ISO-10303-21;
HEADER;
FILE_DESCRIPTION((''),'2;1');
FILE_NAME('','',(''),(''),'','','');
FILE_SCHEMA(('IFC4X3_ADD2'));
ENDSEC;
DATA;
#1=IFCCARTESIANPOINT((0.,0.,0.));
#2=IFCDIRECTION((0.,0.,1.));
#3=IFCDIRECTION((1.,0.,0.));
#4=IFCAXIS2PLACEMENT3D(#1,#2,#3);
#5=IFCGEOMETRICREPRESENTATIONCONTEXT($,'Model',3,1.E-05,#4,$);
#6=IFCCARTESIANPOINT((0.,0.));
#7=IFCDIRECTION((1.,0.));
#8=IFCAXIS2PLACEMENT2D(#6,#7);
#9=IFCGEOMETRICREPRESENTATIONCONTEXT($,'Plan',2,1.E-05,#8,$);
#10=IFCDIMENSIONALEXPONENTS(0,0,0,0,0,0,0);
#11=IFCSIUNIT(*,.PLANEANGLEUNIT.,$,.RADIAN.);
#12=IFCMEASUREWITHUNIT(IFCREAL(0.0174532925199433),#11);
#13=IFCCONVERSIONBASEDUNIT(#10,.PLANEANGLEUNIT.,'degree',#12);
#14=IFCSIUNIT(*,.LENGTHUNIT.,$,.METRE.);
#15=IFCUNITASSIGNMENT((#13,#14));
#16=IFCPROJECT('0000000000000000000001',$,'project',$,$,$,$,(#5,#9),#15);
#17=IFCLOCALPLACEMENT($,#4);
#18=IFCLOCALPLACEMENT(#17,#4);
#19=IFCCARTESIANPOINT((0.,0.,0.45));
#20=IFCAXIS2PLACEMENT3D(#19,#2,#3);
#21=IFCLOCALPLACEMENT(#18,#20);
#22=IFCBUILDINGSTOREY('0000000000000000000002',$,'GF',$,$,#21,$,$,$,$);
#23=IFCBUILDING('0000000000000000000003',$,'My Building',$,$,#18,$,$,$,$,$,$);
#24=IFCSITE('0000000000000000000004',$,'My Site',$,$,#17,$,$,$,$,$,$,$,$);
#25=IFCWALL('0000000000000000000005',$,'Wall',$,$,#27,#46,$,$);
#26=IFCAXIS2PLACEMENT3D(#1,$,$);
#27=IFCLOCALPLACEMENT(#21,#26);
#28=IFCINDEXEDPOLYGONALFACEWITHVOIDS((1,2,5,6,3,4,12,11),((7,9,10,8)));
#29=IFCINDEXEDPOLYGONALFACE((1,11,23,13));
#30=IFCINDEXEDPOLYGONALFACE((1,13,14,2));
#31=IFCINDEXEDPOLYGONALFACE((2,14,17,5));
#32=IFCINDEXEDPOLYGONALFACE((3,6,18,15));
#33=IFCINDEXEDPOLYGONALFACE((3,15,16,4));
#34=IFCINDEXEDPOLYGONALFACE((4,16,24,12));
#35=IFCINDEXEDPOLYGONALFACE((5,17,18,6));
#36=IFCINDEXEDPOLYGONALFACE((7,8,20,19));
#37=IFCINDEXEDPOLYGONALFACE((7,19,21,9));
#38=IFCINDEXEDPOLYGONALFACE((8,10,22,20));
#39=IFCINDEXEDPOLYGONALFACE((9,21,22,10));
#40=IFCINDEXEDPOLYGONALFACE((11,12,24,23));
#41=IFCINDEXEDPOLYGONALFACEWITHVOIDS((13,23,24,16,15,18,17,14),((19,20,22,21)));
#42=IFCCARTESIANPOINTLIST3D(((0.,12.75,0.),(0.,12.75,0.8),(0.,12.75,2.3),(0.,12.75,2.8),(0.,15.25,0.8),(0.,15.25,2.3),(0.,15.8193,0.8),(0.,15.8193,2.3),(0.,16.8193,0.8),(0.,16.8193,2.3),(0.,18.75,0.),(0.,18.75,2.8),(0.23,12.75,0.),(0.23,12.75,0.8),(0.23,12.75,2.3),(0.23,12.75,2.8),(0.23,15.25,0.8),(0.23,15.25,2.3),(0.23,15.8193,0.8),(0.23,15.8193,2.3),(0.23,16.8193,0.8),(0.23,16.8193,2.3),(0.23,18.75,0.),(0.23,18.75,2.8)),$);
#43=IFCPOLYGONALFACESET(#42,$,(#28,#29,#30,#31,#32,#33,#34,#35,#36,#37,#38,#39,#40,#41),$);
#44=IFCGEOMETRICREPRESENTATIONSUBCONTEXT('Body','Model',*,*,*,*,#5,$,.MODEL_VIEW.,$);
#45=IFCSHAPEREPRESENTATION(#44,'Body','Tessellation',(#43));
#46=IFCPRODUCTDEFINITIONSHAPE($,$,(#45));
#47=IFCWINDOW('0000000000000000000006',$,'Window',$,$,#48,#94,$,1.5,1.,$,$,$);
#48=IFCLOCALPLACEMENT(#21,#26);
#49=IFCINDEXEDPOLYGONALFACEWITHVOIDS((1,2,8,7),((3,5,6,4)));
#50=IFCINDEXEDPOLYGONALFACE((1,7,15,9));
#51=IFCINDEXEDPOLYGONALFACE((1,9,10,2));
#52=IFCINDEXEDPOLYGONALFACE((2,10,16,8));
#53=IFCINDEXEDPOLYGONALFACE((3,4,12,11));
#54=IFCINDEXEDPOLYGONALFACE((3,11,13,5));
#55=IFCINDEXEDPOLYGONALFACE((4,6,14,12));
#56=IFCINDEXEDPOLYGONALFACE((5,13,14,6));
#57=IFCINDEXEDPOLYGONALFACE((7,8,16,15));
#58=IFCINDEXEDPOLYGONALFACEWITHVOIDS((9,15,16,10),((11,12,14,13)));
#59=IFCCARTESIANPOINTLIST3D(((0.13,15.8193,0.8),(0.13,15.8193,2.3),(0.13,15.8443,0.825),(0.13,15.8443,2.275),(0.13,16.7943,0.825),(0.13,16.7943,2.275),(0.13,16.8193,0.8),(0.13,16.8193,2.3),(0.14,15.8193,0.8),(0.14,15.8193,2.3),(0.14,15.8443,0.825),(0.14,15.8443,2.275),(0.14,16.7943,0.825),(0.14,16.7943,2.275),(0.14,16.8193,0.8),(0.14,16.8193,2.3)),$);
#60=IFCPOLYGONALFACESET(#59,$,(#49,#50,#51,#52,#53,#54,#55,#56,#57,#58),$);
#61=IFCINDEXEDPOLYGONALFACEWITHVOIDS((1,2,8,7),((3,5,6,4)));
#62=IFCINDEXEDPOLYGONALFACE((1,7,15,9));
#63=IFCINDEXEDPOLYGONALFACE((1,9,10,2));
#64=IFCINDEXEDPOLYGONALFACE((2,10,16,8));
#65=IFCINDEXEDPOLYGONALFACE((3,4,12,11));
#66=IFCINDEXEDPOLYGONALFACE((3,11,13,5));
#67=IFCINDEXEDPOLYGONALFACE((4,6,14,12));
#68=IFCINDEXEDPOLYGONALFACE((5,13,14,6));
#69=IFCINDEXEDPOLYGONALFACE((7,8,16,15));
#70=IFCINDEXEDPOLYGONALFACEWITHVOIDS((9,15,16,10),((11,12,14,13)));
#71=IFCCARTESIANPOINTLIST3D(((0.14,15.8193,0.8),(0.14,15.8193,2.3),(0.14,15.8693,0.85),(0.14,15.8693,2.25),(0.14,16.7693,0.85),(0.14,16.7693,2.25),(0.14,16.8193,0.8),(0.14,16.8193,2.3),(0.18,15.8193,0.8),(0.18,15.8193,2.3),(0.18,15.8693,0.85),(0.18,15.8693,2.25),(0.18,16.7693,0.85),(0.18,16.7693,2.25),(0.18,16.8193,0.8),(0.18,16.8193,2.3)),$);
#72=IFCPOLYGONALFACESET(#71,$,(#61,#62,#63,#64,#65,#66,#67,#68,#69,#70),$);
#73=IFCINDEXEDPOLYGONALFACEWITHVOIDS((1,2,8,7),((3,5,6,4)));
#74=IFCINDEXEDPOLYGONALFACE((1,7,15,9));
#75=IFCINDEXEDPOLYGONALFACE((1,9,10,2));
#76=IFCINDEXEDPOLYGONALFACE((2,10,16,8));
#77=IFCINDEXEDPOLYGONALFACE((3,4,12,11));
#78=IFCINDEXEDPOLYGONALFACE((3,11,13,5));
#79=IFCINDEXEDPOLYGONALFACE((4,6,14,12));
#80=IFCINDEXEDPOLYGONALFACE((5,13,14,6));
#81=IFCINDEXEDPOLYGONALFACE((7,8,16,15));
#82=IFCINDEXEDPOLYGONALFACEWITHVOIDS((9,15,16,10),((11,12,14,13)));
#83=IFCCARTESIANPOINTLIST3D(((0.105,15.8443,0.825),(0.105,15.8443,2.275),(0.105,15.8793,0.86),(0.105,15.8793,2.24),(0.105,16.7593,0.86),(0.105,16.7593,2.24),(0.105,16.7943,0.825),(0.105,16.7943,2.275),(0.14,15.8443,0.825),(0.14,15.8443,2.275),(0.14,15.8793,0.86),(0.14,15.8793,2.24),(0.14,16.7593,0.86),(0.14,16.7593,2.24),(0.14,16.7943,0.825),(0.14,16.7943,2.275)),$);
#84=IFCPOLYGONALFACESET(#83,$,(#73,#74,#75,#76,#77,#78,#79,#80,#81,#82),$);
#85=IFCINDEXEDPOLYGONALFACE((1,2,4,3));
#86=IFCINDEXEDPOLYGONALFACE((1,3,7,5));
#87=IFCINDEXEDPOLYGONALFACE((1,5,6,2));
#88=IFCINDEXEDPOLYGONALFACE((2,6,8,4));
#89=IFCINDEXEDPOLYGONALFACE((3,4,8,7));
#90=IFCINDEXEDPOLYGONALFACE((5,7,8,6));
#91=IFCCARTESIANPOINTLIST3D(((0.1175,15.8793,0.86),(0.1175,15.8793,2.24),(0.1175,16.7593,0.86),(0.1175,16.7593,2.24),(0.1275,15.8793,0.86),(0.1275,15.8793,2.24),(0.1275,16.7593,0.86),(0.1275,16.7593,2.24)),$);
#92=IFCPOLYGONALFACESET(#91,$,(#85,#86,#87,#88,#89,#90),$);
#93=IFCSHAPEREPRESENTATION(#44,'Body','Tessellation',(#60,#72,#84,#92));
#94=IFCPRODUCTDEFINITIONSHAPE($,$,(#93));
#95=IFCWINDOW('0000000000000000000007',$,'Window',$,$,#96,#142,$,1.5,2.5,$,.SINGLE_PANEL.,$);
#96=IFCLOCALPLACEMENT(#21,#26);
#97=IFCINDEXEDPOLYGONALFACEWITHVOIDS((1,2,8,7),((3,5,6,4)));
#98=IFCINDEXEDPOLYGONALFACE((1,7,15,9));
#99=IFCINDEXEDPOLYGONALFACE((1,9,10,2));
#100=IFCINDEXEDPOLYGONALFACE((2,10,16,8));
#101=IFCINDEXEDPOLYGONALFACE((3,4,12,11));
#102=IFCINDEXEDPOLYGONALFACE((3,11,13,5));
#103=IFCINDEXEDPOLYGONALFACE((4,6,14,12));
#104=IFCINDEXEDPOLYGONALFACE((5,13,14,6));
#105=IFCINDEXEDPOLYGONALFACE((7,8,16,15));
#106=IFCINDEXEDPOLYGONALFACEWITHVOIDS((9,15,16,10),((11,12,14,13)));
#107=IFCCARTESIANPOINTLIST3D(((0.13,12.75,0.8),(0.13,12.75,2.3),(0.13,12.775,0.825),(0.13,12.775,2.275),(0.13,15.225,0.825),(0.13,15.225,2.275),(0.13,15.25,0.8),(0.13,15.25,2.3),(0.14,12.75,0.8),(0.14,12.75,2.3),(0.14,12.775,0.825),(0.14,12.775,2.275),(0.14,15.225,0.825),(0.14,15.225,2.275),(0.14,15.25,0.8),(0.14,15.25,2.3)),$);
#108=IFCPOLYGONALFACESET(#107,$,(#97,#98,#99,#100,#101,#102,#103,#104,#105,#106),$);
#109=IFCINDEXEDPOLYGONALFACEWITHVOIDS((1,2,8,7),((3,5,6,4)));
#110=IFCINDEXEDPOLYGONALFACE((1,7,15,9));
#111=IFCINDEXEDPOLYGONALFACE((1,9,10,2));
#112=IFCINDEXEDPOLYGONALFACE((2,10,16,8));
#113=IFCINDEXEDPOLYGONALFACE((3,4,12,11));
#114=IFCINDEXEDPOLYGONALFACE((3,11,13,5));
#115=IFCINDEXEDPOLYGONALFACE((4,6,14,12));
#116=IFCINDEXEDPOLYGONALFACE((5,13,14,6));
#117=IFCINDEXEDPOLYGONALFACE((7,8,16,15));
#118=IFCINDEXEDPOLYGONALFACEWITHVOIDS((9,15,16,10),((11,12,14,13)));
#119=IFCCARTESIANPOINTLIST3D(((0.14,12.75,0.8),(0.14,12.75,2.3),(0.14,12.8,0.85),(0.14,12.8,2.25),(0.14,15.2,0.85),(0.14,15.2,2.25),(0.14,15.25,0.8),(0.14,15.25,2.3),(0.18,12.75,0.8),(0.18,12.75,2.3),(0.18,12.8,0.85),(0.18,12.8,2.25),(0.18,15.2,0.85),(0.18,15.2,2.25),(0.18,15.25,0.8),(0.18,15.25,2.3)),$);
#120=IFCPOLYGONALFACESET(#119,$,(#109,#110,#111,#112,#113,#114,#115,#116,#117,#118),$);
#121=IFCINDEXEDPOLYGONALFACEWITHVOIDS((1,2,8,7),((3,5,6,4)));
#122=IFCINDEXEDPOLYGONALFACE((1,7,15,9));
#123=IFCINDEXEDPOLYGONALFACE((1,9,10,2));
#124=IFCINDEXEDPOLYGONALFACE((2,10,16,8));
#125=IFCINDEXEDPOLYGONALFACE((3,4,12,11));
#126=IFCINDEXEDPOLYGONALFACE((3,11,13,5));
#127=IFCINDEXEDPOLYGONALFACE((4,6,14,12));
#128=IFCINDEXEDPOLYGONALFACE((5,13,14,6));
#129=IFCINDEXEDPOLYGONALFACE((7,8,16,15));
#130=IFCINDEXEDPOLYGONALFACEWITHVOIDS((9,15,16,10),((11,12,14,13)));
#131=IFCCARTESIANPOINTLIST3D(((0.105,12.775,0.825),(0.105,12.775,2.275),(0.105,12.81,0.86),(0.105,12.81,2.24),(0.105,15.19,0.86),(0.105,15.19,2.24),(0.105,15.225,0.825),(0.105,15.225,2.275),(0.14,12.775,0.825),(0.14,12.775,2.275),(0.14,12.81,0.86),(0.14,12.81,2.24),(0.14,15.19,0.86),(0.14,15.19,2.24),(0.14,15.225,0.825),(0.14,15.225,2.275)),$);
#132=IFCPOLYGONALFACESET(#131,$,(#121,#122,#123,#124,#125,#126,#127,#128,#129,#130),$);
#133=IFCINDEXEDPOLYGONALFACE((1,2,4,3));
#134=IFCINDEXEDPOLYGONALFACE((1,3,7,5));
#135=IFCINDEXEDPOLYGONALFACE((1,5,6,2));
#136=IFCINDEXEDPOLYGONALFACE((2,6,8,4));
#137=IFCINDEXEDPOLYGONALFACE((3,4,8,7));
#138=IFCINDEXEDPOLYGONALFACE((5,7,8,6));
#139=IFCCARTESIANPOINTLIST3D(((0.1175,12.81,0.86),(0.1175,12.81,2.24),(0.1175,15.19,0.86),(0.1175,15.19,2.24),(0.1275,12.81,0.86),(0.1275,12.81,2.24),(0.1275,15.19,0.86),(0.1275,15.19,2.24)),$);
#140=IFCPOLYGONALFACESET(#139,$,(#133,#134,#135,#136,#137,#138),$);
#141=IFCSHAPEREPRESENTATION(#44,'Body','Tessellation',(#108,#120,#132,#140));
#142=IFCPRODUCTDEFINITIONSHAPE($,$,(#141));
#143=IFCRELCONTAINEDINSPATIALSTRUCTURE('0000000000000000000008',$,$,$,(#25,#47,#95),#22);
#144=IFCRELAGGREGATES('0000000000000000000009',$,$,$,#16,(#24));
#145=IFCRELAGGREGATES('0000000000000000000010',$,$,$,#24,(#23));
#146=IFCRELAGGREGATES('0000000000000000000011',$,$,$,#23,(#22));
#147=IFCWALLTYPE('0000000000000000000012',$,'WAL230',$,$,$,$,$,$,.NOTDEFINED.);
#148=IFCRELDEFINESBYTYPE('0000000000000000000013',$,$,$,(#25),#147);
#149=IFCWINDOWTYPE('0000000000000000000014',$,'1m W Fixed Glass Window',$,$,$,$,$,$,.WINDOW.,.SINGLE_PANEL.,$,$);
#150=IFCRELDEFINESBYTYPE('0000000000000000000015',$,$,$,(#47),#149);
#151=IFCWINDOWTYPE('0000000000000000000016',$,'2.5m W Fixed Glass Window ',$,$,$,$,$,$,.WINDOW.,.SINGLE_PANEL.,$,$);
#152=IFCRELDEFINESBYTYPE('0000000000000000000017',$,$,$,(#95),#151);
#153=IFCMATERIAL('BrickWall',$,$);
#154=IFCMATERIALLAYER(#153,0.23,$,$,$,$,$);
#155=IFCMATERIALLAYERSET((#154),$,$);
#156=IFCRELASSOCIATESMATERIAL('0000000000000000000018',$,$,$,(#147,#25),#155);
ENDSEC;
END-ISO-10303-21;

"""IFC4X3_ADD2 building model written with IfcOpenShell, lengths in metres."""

from ifc_helpers import new_model, entity, si_unit, converted_unit, frame, origin_with_axes, origin_2d_with_axis, place, context, subcontext, project, spatial, line, indexed_curve, outline, extrude, shape, source, transform, mapped, material, layer, layer_set, layer_usage, type_object, type_shapes, element, fill, save


model = new_model("IFC4X3_ADD2")

# Units and contexts
model_context = context("Model", 3, precision=1e-05, world=origin_with_axes())
plan_context = context("Plan", 2, precision=1e-05, world=origin_2d_with_axis())
body_context_1 = subcontext(model_context, "Body", "Model", "MODEL_VIEW")
body_context_2 = subcontext(plan_context, "Body", "Plan", "PLAN_VIEW")
ifc_project = project(units=[converted_unit("PLANEANGLEUNIT", "degree", entity("IfcReal", 0.0174532925199433), si_unit("PLANEANGLEUNIT", "RADIAN"), dimensions=[0, 0, 0, 0, 0, 0, 0]), si_unit("LENGTHUNIT", "METRE")], contexts=[model_context, plan_context])

# Site, building, storey
site_placement = place(None, origin_with_axes())
site = spatial("IfcSite", under=ifc_project, at=site_placement, Name="My Site")
building_placement = place(site_placement, origin_with_axes())
building = spatial("IfcBuilding", under=site, at=building_placement, Name="My Building")
storey_placement = place(building_placement, frame((0.0, 0.0, 0.45), z_axis=(0.0, 0.0, 1.0), x_axis=(1.0, 0.0, 0.0)))
storey = spatial("IfcBuildingStorey", under=building, at=storey_placement, Name="GF")

# Wall, openings, windows
ifc_material_1 = material(Name="BrickWall")
ifc_layer_1 = layer(ifc_material_1, 0.23)
ifc_layer_set_1 = layer_set([ifc_layer_1])
ifc_layer_usage_1 = layer_usage(ifc_layer_set_1, "AXIS2", "POSITIVE", 0.0)
wall_type_1 = type_object("IfcWallType", Name="WAL230", PredefinedType="NOTDEFINED", material=ifc_layer_set_1)
wall_1_placement = place(storey_placement, frame((0.23, 12.75, 0.0), z_axis=(0.0, 0.0, 1.0), x_axis=(0.0, 1.0, 0.0)))
wall_1 = element("IfcWall", 1, at=wall_1_placement, inside=storey, type_object=wall_type_1, material=ifc_layer_usage_1, Name="Wall", context=body_context_1, shape_type="SweptSolid", body=[
    extrude(outline(indexed_curve([(0.0, 0.0), (0.0, 0.23), (6.0, 0.23), (6.0, 0.0), (0.0, 0.0)], self_intersect=False)), origin_with_axes(), (0.0, 0.0, 1.0), 2.8),
])
shared_shape_1 = source(origin_with_axes(), body_context_1, "Body", "SweptSolid", [
    extrude(outline(indexed_curve([(0.0, 0.0), (2.5, 0.0), (2.5, 1.5), (0.0, 1.5)], segments=[line(1, 2, 3, 4, 1)])), frame((0.0, -0.6, 0.0), z_axis=(0.0, -1.0, 0.0), x_axis=(1.0, 0.0, 0.0)), (0.0, 0.0, -1.0), 1.2),
])
opening_1_placement = place(wall_1_placement, frame((0.0, 0.0, 0.8), z_axis=(0.0, 0.0, 1.0), x_axis=(1.0, 0.0, 0.0)))
opening_1 = element("IfcOpeningElement", 2, at=opening_1_placement, cuts=wall_1, PredefinedType="OPENING", context=body_context_1, shape_type="MappedRepresentation", body=[
    mapped(shared_shape_1, transform((0.0, 0.0, 0.0), x_axis=(1.0, 0.0, 0.0), y_axis=(0.0, 1.0, 0.0), z_axis=(0.0, 0.0, 1.0), scale=1.0)),
])
shared_shape_2 = source(origin_with_axes(), body_context_1, "Body", "SweptSolid", [
    extrude(outline(indexed_curve([(0.0, 0.0), (1.0, 0.0), (1.0, 1.5), (0.0, 1.5)], segments=[line(1, 2, 3, 4, 1)])), frame((0.0, -0.6, 0.0), z_axis=(0.0, -1.0, 0.0), x_axis=(1.0, 0.0, 0.0)), (0.0, 0.0, -1.0), 1.2),
])
opening_2_placement = place(wall_1_placement, frame((3.0693, 0.0, 0.8), z_axis=(0.0, 0.0, 1.0), x_axis=(1.0, 0.0, 0.0)))
opening_2 = element("IfcOpeningElement", 3, at=opening_2_placement, cuts=wall_1, PredefinedType="OPENING", context=body_context_1, shape_type="MappedRepresentation", body=[
    mapped(shared_shape_2, transform((0.0, 0.0, 0.0), x_axis=(1.0, 0.0, 0.0), y_axis=(0.0, 1.0, 0.0), z_axis=(0.0, 0.0, 1.0), scale=1.0)),
])
window_type_1 = type_object("IfcWindowType", Name="1m W Fixed Glass Window", PartitioningType="SINGLE_PANEL", PredefinedType="WINDOW")
shared_shape_3 = source(origin_with_axes(), body_context_1, "Body", "SweptSolid", [
    extrude(outline(indexed_curve([(0.0, 0.0), (1.0, 0.0), (1.0, 1.5), (0.0, 1.5)], segments=[line(1, 2, 3, 4, 1)]), holes=[indexed_curve([(0.025, 0.025), (0.975, 0.025), (0.975, 1.475), (0.025, 1.475)], segments=[line(1, 2, 3, 4, 1)])]), frame((0.0, 0.09, 0.0), z_axis=(0.0, -1.0, 0.0), x_axis=(1.0, 0.0, 0.0)), (0.0, 0.0, -1.0), 0.01),
    extrude(outline(indexed_curve([(0.0, 0.0), (1.0, 0.0), (1.0, 1.5), (0.0, 1.5)], segments=[line(1, 2, 3, 4, 1)]), holes=[indexed_curve([(0.05, 0.05), (0.95, 0.05), (0.95, 1.45), (0.05, 1.45)], segments=[line(1, 2, 3, 4, 1)])]), frame((0.0, 0.05, 0.0), z_axis=(0.0, -1.0, 0.0), x_axis=(1.0, 0.0, 0.0)), (0.0, 0.0, -1.0), 0.04),
    extrude(outline(indexed_curve([(0.0, 0.0), (0.95, 0.0), (0.95, 1.45), (0.0, 1.45)], segments=[line(1, 2, 3, 4, 1)]), holes=[indexed_curve([(0.035, 0.035), (0.915, 0.035), (0.915, 1.415), (0.035, 1.415)], segments=[line(1, 2, 3, 4, 1)])]), frame((0.025, 0.09, 0.025), z_axis=(0.0, -1.0, 0.0), x_axis=(1.0, 0.0, 0.0)), (0.0, 0.0, -1.0), 0.035),
    extrude(outline(indexed_curve([(0.035, 0.035), (0.915, 0.035), (0.915, 1.415), (0.035, 1.415)], segments=[line(1, 2, 3, 4, 1)])), frame((0.025, 0.1025, 0.025), z_axis=(0.0, -1.0, 0.0), x_axis=(1.0, 0.0, 0.0)), (0.0, 0.0, -1.0), 0.01),
])
shared_shape_4 = source(origin_with_axes(), body_context_2, "Body", "Curve2D", [
    entity("IfcIndexedPolyCurve", entity("IfcCartesianPointList2D", [[0.05, 0.05], [0.95, 0.05]])),
    entity("IfcIndexedPolyCurve", entity("IfcCartesianPointList2D", [[0.0, 0.1], [0.025, 0.1], [0.025, 0.09], [0.05, 0.09], [0.05, 0.05], [0.0, 0.05]]), [entity("IfcLineIndex", [1, 2, 3, 4, 5, 6, 1])]),
    entity("IfcIndexedPolyCurve", entity("IfcCartesianPointList2D", [[1.0, 0.1], [0.975, 0.1], [0.975, 0.09], [0.95, 0.09], [0.95, 0.05], [1.0, 0.05]]), [entity("IfcLineIndex", [1, 2, 3, 4, 5, 6, 1])]),
    entity("IfcIndexedPolyCurve", entity("IfcCartesianPointList2D", [[0.025, 0.09], [0.06, 0.09], [0.06, 0.125], [0.025, 0.125]]), [entity("IfcLineIndex", [1, 2, 3, 4, 1])]),
    entity("IfcIndexedPolyCurve", entity("IfcCartesianPointList2D", [[0.975, 0.09], [0.94, 0.09], [0.94, 0.125], [0.975, 0.125]]), [entity("IfcLineIndex", [1, 2, 3, 4, 1])]),
    entity("IfcIndexedPolyCurve", entity("IfcCartesianPointList2D", [[0.06, 0.09], [0.94, 0.09]])),
    entity("IfcIndexedPolyCurve", entity("IfcCartesianPointList2D", [[0.06, 0.125], [0.94, 0.125]])),
    entity("IfcIndexedPolyCurve", entity("IfcCartesianPointList2D", [[0.06, 0.1075], [0.94, 0.1075]])),
])
type_shapes(window_type_1, [shared_shape_3, shared_shape_4])
window_1_placement = place(opening_2_placement, origin_with_axes())
window_1 = element("IfcWindow", 4, at=window_1_placement, inside=storey, type_object=window_type_1, Name="Window", OverallHeight=1.5, OverallWidth=1.0, shapes=[
    shape(body_context_1, "Body", "MappedRepresentation", [mapped(shared_shape_3, transform((0.0, 0.0, 0.0), x_axis=(1.0, 0.0, 0.0), y_axis=(0.0, 1.0, 0.0), z_axis=(0.0, 0.0, 1.0), scale=1.0))]),
    shape(body_context_2, "Body", "MappedRepresentation", [mapped(shared_shape_4, transform((0.0, 0.0, 0.0), x_axis=(1.0, 0.0, 0.0), y_axis=(0.0, 1.0, 0.0), z_axis=(0.0, 0.0, 1.0), scale=1.0))]),
])
fill(opening_2, window_1)
window_type_2 = type_object("IfcWindowType", Name="2.5m W Fixed Glass Window ", PartitioningType="SINGLE_PANEL", PredefinedType="WINDOW")
shared_shape_5 = source(origin_with_axes(), body_context_1, "Body", "SweptSolid", [
    extrude(outline(indexed_curve([(0.0, 0.0), (2.5, 0.0), (2.5, 1.5), (0.0, 1.5)], segments=[line(1, 2, 3, 4, 1)]), holes=[indexed_curve([(0.025, 0.025), (2.475, 0.025), (2.475, 1.475), (0.025, 1.475)], segments=[line(1, 2, 3, 4, 1)])]), frame((0.0, 0.09, 0.0), z_axis=(0.0, -1.0, 0.0), x_axis=(1.0, 0.0, 0.0)), (0.0, 0.0, -1.0), 0.01),
    extrude(outline(indexed_curve([(0.0, 0.0), (2.5, 0.0), (2.5, 1.5), (0.0, 1.5)], segments=[line(1, 2, 3, 4, 1)]), holes=[indexed_curve([(0.05, 0.05), (2.45, 0.05), (2.45, 1.45), (0.05, 1.45)], segments=[line(1, 2, 3, 4, 1)])]), frame((0.0, 0.05, 0.0), z_axis=(0.0, -1.0, 0.0), x_axis=(1.0, 0.0, 0.0)), (0.0, 0.0, -1.0), 0.04),
    extrude(outline(indexed_curve([(0.0, 0.0), (2.45, 0.0), (2.45, 1.45), (0.0, 1.45)], segments=[line(1, 2, 3, 4, 1)]), holes=[indexed_curve([(0.035, 0.035), (2.415, 0.035), (2.415, 1.415), (0.035, 1.415)], segments=[line(1, 2, 3, 4, 1)])]), frame((0.025, 0.09, 0.025), z_axis=(0.0, -1.0, 0.0), x_axis=(1.0, 0.0, 0.0)), (0.0, 0.0, -1.0), 0.035),
    extrude(outline(indexed_curve([(0.035, 0.035), (2.415, 0.035), (2.415, 1.415), (0.035, 1.415)], segments=[line(1, 2, 3, 4, 1)])), frame((0.025, 0.1025, 0.025), z_axis=(0.0, -1.0, 0.0), x_axis=(1.0, 0.0, 0.0)), (0.0, 0.0, -1.0), 0.01),
])
shared_shape_6 = source(origin_with_axes(), body_context_2, "Body", "Curve2D", [
    entity("IfcIndexedPolyCurve", entity("IfcCartesianPointList2D", [[0.05, 0.05], [2.45, 0.05]])),
    entity("IfcIndexedPolyCurve", entity("IfcCartesianPointList2D", [[0.0, 0.1], [0.025, 0.1], [0.025, 0.09], [0.05, 0.09], [0.05, 0.05], [0.0, 0.05]]), [entity("IfcLineIndex", [1, 2, 3, 4, 5, 6, 1])]),
    entity("IfcIndexedPolyCurve", entity("IfcCartesianPointList2D", [[2.5, 0.1], [2.475, 0.1], [2.475, 0.09], [2.45, 0.09], [2.45, 0.05], [2.5, 0.05]]), [entity("IfcLineIndex", [1, 2, 3, 4, 5, 6, 1])]),
    entity("IfcIndexedPolyCurve", entity("IfcCartesianPointList2D", [[0.025, 0.09], [0.06, 0.09], [0.06, 0.125], [0.025, 0.125]]), [entity("IfcLineIndex", [1, 2, 3, 4, 1])]),
    entity("IfcIndexedPolyCurve", entity("IfcCartesianPointList2D", [[2.475, 0.09], [2.44, 0.09], [2.44, 0.125], [2.475, 0.125]]), [entity("IfcLineIndex", [1, 2, 3, 4, 1])]),
    entity("IfcIndexedPolyCurve", entity("IfcCartesianPointList2D", [[0.06, 0.09], [2.44, 0.09]])),
    entity("IfcIndexedPolyCurve", entity("IfcCartesianPointList2D", [[0.06, 0.125], [2.44, 0.125]])),
    entity("IfcIndexedPolyCurve", entity("IfcCartesianPointList2D", [[0.06, 0.1075], [2.44, 0.1075]])),
])
type_shapes(window_type_2, [shared_shape_5, shared_shape_6])
window_2_placement = place(opening_1_placement, origin_with_axes())
window_2 = element("IfcWindow", 5, at=window_2_placement, inside=storey, type_object=window_type_2, Name="Window", OverallHeight=1.5, OverallWidth=2.5, PartitioningType="SINGLE_PANEL", shapes=[
    shape(body_context_1, "Body", "MappedRepresentation", [mapped(shared_shape_5, transform((0.0, 0.0, 0.0), x_axis=(1.0, 0.0, 0.0), y_axis=(0.0, 1.0, 0.0), z_axis=(0.0, 0.0, 1.0), scale=1.0))]),
    shape(body_context_2, "Body", "MappedRepresentation", [mapped(shared_shape_6, transform((0.0, 0.0, 0.0), x_axis=(1.0, 0.0, 0.0), y_axis=(0.0, 1.0, 0.0), z_axis=(0.0, 0.0, 1.0), scale=1.0))]),
])
fill(opening_1, window_2)

save(model, "model.ifc")
